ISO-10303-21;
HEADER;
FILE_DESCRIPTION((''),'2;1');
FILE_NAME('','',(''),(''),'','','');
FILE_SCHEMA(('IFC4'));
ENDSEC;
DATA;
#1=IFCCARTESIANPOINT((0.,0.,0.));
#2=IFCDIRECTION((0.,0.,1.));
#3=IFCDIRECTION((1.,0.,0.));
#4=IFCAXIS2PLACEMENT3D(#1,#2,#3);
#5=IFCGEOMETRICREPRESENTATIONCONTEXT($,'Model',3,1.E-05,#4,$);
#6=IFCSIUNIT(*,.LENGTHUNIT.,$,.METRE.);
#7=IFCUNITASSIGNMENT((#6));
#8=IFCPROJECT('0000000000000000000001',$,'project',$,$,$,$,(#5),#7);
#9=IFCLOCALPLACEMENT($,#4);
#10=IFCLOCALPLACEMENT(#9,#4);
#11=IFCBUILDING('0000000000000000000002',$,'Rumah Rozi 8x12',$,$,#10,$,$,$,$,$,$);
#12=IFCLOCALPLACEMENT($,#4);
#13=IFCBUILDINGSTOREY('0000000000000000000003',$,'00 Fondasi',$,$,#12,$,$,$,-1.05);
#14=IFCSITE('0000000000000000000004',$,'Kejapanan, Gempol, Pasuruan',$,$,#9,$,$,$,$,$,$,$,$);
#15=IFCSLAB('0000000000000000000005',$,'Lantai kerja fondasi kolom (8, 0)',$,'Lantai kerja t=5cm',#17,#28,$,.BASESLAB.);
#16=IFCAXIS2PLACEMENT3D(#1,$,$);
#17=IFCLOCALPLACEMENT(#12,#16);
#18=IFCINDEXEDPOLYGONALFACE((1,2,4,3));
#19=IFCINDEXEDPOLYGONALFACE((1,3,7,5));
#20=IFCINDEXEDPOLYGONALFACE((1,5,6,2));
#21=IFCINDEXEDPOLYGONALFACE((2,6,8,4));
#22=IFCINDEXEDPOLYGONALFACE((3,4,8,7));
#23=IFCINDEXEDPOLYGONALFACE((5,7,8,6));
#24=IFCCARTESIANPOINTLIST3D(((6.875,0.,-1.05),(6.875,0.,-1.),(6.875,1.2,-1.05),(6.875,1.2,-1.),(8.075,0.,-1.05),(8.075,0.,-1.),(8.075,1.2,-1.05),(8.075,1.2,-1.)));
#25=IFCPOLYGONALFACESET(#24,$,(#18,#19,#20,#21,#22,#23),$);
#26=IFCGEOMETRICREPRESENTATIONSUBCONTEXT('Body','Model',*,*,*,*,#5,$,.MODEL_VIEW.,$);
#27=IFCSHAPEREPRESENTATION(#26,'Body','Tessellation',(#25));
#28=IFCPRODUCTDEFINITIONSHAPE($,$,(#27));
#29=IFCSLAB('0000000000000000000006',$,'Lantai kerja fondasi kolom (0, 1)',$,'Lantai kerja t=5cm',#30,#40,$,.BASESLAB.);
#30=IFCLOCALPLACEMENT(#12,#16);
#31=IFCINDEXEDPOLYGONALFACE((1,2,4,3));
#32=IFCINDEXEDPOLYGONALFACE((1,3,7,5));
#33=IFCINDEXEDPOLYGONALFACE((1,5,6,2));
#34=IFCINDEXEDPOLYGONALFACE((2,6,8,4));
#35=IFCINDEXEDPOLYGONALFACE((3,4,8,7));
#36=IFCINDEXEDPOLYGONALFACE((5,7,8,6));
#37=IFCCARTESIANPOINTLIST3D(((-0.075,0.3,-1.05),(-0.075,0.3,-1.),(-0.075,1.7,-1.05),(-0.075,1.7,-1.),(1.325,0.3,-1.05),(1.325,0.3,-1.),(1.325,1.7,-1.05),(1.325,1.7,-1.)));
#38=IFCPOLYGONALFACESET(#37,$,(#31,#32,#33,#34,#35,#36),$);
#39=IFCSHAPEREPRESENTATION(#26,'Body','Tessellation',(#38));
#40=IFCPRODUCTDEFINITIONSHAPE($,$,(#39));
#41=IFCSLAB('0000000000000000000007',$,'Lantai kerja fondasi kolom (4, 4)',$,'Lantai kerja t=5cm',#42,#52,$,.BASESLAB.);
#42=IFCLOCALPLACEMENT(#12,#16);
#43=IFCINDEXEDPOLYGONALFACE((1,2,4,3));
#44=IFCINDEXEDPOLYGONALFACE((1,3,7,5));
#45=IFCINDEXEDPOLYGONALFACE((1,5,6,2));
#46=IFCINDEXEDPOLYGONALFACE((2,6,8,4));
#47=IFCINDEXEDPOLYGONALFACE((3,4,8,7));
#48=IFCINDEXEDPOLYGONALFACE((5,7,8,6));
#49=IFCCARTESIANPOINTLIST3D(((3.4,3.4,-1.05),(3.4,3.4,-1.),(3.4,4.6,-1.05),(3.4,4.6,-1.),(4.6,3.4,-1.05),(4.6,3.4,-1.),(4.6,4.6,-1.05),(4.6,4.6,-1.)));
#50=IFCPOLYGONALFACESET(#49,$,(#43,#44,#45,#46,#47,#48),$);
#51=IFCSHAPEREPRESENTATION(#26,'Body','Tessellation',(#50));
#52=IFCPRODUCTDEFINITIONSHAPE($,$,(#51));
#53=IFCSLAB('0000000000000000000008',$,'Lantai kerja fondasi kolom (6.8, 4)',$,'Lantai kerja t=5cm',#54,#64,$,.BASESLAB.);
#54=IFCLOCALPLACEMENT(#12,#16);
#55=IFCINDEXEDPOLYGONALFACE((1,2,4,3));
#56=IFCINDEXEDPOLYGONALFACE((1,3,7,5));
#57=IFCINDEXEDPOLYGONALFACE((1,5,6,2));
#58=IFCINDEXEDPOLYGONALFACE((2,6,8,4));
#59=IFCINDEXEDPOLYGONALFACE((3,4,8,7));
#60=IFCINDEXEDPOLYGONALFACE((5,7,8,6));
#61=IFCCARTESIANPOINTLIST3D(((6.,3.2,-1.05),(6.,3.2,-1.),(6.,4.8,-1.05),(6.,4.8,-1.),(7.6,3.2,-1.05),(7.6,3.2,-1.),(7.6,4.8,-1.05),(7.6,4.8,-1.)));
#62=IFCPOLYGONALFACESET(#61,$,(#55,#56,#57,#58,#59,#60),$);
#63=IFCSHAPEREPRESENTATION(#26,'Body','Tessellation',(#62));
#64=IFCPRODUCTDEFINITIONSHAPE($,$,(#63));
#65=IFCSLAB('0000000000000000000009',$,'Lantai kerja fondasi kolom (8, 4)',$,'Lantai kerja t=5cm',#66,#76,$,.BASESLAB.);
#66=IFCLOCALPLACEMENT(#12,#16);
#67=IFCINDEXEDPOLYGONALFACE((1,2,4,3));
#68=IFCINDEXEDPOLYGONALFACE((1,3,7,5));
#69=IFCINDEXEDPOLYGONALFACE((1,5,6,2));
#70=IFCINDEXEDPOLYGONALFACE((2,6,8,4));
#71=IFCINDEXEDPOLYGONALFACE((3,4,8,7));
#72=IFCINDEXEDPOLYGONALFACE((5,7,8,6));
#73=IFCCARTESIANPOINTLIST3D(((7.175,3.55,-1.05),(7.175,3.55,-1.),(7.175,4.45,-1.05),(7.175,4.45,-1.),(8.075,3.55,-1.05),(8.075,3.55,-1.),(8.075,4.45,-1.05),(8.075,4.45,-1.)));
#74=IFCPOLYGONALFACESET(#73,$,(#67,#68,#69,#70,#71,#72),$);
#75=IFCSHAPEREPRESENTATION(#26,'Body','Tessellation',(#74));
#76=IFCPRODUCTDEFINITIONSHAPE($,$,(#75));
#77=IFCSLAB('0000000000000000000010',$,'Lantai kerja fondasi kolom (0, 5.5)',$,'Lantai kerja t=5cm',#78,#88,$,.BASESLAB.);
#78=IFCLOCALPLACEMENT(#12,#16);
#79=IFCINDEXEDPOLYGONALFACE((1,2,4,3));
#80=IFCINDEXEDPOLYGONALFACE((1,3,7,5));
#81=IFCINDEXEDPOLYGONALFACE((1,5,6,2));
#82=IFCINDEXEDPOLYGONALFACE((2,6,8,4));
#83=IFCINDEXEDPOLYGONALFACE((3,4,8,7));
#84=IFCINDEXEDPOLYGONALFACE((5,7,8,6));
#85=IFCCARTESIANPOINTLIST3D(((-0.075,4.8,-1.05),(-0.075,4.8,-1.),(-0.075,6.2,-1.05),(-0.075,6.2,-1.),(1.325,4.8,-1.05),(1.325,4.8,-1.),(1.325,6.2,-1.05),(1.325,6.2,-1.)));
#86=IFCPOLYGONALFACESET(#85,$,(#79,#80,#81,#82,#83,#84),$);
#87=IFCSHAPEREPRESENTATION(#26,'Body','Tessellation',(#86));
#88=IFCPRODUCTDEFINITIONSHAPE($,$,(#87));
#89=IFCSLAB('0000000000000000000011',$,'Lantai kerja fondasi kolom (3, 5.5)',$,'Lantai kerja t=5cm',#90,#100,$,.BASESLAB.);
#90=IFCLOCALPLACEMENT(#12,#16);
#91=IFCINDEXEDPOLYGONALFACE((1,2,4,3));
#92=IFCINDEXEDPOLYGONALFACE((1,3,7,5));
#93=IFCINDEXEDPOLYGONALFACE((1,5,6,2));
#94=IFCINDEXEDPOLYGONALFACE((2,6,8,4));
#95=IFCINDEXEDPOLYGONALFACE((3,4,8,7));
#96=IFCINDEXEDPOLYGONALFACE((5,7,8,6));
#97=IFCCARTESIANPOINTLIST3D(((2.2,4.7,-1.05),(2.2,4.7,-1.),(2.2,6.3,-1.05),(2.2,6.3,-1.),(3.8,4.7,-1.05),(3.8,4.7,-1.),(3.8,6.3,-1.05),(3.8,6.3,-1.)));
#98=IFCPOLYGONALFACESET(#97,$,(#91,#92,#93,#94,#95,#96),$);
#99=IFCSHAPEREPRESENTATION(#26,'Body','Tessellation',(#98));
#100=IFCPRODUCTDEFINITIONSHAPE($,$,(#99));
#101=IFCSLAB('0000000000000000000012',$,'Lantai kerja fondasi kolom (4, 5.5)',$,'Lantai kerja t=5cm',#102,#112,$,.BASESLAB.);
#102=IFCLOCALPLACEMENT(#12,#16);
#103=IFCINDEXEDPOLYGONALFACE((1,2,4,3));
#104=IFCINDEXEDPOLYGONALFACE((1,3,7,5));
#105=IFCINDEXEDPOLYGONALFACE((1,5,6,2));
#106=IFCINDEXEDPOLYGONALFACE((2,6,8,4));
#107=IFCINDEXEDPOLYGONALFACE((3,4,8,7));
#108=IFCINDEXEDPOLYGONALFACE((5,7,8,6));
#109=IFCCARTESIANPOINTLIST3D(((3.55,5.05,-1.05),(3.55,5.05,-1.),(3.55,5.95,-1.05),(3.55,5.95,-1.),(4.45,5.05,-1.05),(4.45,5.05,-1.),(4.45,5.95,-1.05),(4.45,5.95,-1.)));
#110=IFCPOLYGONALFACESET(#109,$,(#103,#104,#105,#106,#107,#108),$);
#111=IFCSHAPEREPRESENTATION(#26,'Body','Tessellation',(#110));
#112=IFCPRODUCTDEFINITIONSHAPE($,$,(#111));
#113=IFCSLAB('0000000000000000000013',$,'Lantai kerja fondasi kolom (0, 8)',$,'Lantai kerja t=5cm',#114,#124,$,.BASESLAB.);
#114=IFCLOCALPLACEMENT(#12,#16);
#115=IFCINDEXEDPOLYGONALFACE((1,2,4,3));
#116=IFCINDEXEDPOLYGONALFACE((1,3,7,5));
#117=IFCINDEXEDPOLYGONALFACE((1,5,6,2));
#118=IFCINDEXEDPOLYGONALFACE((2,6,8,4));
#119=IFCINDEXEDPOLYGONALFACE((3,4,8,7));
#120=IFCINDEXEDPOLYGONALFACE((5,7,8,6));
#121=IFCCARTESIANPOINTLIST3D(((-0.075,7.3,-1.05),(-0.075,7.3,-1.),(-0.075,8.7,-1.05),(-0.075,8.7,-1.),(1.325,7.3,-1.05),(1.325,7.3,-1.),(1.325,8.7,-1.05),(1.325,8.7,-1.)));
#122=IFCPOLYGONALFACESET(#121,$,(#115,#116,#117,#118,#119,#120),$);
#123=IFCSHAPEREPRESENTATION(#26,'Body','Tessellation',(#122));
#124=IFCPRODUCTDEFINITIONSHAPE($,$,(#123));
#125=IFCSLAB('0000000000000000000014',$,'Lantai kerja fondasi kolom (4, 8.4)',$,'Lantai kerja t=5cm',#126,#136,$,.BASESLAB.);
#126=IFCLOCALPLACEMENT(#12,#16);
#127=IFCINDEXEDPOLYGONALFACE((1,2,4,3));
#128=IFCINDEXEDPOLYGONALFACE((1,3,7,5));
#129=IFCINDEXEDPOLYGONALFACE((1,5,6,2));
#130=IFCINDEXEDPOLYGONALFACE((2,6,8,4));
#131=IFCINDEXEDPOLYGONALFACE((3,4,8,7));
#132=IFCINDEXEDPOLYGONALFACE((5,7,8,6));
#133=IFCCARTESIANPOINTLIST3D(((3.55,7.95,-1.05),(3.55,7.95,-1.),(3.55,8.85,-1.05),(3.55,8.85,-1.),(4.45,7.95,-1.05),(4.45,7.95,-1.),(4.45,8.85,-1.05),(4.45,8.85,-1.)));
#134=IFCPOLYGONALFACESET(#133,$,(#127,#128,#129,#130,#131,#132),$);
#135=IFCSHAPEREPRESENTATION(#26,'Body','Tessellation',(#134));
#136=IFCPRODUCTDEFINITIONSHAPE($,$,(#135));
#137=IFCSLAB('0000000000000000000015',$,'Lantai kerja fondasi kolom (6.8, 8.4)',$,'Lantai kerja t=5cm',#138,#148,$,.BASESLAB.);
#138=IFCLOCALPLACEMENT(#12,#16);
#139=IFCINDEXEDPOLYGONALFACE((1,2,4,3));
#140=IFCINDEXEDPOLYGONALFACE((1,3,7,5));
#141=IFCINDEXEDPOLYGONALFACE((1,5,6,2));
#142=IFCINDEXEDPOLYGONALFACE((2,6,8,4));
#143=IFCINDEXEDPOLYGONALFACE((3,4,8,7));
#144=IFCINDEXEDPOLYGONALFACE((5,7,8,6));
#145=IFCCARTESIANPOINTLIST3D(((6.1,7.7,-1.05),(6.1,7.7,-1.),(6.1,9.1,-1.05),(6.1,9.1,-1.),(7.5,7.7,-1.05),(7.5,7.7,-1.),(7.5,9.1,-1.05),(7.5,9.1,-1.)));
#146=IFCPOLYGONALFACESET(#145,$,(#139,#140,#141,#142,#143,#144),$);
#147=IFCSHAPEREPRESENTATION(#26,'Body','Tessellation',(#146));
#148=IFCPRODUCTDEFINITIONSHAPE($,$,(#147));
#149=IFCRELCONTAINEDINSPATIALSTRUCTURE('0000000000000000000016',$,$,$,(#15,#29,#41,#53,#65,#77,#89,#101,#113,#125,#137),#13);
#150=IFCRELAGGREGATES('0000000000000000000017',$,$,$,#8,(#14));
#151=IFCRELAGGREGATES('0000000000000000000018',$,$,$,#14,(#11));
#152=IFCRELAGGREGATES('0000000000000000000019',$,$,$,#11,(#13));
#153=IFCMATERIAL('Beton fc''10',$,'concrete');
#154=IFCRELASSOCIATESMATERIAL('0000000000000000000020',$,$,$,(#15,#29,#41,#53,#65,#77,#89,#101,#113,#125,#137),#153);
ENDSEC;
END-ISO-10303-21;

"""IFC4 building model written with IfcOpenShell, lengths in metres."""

from ifc_helpers import new_model, si_unit, frame, origin_with_axes, place, context, subcontext, project, spatial, line, indexed_curve, outline, extrude, material, element, save


model = new_model("IFC4")

# Units and contexts
model_context = context("Model", 3, precision=1e-05, world=origin_with_axes())
body_context = subcontext(model_context, "Body", "Model", "MODEL_VIEW")
ifc_project = project(units=[si_unit("LENGTHUNIT", "METRE")], contexts=[model_context])

# Site, building, storey
site_placement = place(None, origin_with_axes())
site = spatial("IfcSite", under=ifc_project, at=site_placement, Name="Kejapanan, Gempol, Pasuruan")
building_placement = place(site_placement, origin_with_axes())
building = spatial("IfcBuilding", under=site, at=building_placement, Name="Rumah Rozi 8x12")
storey_placement = place(None, origin_with_axes())
storey = spatial("IfcBuildingStorey", under=building, at=storey_placement, Name="00 Fondasi", Elevation=-1.05)

# Slabs
ifc_material_1 = material(Name="Beton fc'10", Category="concrete")
slab_1_placement = place(storey_placement, origin_with_axes())
element("IfcSlab", 1, at=slab_1_placement, inside=storey, material=ifc_material_1, Name="Lantai kerja fondasi kolom (8, 0)", ObjectType="Lantai kerja t=5cm", PredefinedType="BASESLAB", context=body_context, shape_type="SweptSolid", body=[
    extrude(outline(indexed_curve([(6.875, 0.0), (8.075, 0.0), (8.075, 1.2), (6.875, 1.2)], segments=[line(1, 2, 3, 4, 1)])), frame((0.0, 0.0, -1.05), z_axis=(0.0, 0.0, 1.0), x_axis=(1.0, 0.0, 0.0)), (0.0, 0.0, 1.0), 0.05),
])
slab_2_placement = place(storey_placement, origin_with_axes())
element("IfcSlab", 2, at=slab_2_placement, inside=storey, material=ifc_material_1, Name="Lantai kerja fondasi kolom (0, 1)", ObjectType="Lantai kerja t=5cm", PredefinedType="BASESLAB", context=body_context, shape_type="SweptSolid", body=[
    extrude(outline(indexed_curve([(-0.075, 0.3), (1.325, 0.3), (1.325, 1.7), (-0.075, 1.7)], segments=[line(1, 2, 3, 4, 1)])), frame((0.0, 0.0, -1.05), z_axis=(0.0, 0.0, 1.0), x_axis=(1.0, 0.0, 0.0)), (0.0, 0.0, 1.0), 0.05),
])
slab_3_placement = place(storey_placement, origin_with_axes())
element("IfcSlab", 3, at=slab_3_placement, inside=storey, material=ifc_material_1, Name="Lantai kerja fondasi kolom (4, 4)", ObjectType="Lantai kerja t=5cm", PredefinedType="BASESLAB", context=body_context, shape_type="SweptSolid", body=[
    extrude(outline(indexed_curve([(3.4, 3.4), (4.6, 3.4), (4.6, 4.6), (3.4, 4.6)], segments=[line(1, 2, 3, 4, 1)])), frame((0.0, 0.0, -1.05), z_axis=(0.0, 0.0, 1.0), x_axis=(1.0, 0.0, 0.0)), (0.0, 0.0, 1.0), 0.05),
])
slab_4_placement = place(storey_placement, origin_with_axes())
element("IfcSlab", 4, at=slab_4_placement, inside=storey, material=ifc_material_1, Name="Lantai kerja fondasi kolom (6.8, 4)", ObjectType="Lantai kerja t=5cm", PredefinedType="BASESLAB", context=body_context, shape_type="SweptSolid", body=[
    extrude(outline(indexed_curve([(6.0, 3.2), (7.6, 3.2), (7.6, 4.8), (6.0, 4.8)], segments=[line(1, 2, 3, 4, 1)])), frame((0.0, 0.0, -1.05), z_axis=(0.0, 0.0, 1.0), x_axis=(1.0, 0.0, 0.0)), (0.0, 0.0, 1.0), 0.05),
])
slab_5_placement = place(storey_placement, origin_with_axes())
element("IfcSlab", 5, at=slab_5_placement, inside=storey, material=ifc_material_1, Name="Lantai kerja fondasi kolom (8, 4)", ObjectType="Lantai kerja t=5cm", PredefinedType="BASESLAB", context=body_context, shape_type="SweptSolid", body=[
    extrude(outline(indexed_curve([(7.175, 3.55), (8.075, 3.55), (8.075, 4.45), (7.175, 4.45)], segments=[line(1, 2, 3, 4, 1)])), frame((0.0, 0.0, -1.05), z_axis=(0.0, 0.0, 1.0), x_axis=(1.0, 0.0, 0.0)), (0.0, 0.0, 1.0), 0.05),
])
slab_6_placement = place(storey_placement, origin_with_axes())
element("IfcSlab", 6, at=slab_6_placement, inside=storey, material=ifc_material_1, Name="Lantai kerja fondasi kolom (0, 5.5)", ObjectType="Lantai kerja t=5cm", PredefinedType="BASESLAB", context=body_context, shape_type="SweptSolid", body=[
    extrude(outline(indexed_curve([(-0.075, 4.8), (1.325, 4.8), (1.325, 6.2), (-0.075, 6.2)], segments=[line(1, 2, 3, 4, 1)])), frame((0.0, 0.0, -1.05), z_axis=(0.0, 0.0, 1.0), x_axis=(1.0, 0.0, 0.0)), (0.0, 0.0, 1.0), 0.05),
])
slab_7_placement = place(storey_placement, origin_with_axes())
element("IfcSlab", 7, at=slab_7_placement, inside=storey, material=ifc_material_1, Name="Lantai kerja fondasi kolom (3, 5.5)", ObjectType="Lantai kerja t=5cm", PredefinedType="BASESLAB", context=body_context, shape_type="SweptSolid", body=[
    extrude(outline(indexed_curve([(2.2, 4.7), (3.8, 4.7), (3.8, 6.3), (2.2, 6.3)], segments=[line(1, 2, 3, 4, 1)])), frame((0.0, 0.0, -1.05), z_axis=(0.0, 0.0, 1.0), x_axis=(1.0, 0.0, 0.0)), (0.0, 0.0, 1.0), 0.05),
])
slab_8_placement = place(storey_placement, origin_with_axes())
element("IfcSlab", 8, at=slab_8_placement, inside=storey, material=ifc_material_1, Name="Lantai kerja fondasi kolom (4, 5.5)", ObjectType="Lantai kerja t=5cm", PredefinedType="BASESLAB", context=body_context, shape_type="SweptSolid", body=[
    extrude(outline(indexed_curve([(3.55, 5.05), (4.45, 5.05), (4.45, 5.95), (3.55, 5.95)], segments=[line(1, 2, 3, 4, 1)])), frame((0.0, 0.0, -1.05), z_axis=(0.0, 0.0, 1.0), x_axis=(1.0, 0.0, 0.0)), (0.0, 0.0, 1.0), 0.05),
])
slab_9_placement = place(storey_placement, origin_with_axes())
element("IfcSlab", 9, at=slab_9_placement, inside=storey, material=ifc_material_1, Name="Lantai kerja fondasi kolom (0, 8)", ObjectType="Lantai kerja t=5cm", PredefinedType="BASESLAB", context=body_context, shape_type="SweptSolid", body=[
    extrude(outline(indexed_curve([(-0.075, 7.3), (1.325, 7.3), (1.325, 8.7), (-0.075, 8.7)], segments=[line(1, 2, 3, 4, 1)])), frame((0.0, 0.0, -1.05), z_axis=(0.0, 0.0, 1.0), x_axis=(1.0, 0.0, 0.0)), (0.0, 0.0, 1.0), 0.05),
])
slab_10_placement = place(storey_placement, origin_with_axes())
element("IfcSlab", 10, at=slab_10_placement, inside=storey, material=ifc_material_1, Name="Lantai kerja fondasi kolom (4, 8.4)", ObjectType="Lantai kerja t=5cm", PredefinedType="BASESLAB", context=body_context, shape_type="SweptSolid", body=[
    extrude(outline(indexed_curve([(3.55, 7.95), (4.45, 7.95), (4.45, 8.85), (3.55, 8.85)], segments=[line(1, 2, 3, 4, 1)])), frame((0.0, 0.0, -1.05), z_axis=(0.0, 0.0, 1.0), x_axis=(1.0, 0.0, 0.0)), (0.0, 0.0, 1.0), 0.05),
])
slab_11_placement = place(storey_placement, origin_with_axes())
element("IfcSlab", 11, at=slab_11_placement, inside=storey, material=ifc_material_1, Name="Lantai kerja fondasi kolom (6.8, 8.4)", ObjectType="Lantai kerja t=5cm", PredefinedType="BASESLAB", context=body_context, shape_type="SweptSolid", body=[
    extrude(outline(indexed_curve([(6.1, 7.7), (7.5, 7.7), (7.5, 9.1), (6.1, 9.1)], segments=[line(1, 2, 3, 4, 1)])), frame((0.0, 0.0, -1.05), z_axis=(0.0, 0.0, 1.0), x_axis=(1.0, 0.0, 0.0)), (0.0, 0.0, 1.0), 0.05),
])

save(model, "model.ifc")
